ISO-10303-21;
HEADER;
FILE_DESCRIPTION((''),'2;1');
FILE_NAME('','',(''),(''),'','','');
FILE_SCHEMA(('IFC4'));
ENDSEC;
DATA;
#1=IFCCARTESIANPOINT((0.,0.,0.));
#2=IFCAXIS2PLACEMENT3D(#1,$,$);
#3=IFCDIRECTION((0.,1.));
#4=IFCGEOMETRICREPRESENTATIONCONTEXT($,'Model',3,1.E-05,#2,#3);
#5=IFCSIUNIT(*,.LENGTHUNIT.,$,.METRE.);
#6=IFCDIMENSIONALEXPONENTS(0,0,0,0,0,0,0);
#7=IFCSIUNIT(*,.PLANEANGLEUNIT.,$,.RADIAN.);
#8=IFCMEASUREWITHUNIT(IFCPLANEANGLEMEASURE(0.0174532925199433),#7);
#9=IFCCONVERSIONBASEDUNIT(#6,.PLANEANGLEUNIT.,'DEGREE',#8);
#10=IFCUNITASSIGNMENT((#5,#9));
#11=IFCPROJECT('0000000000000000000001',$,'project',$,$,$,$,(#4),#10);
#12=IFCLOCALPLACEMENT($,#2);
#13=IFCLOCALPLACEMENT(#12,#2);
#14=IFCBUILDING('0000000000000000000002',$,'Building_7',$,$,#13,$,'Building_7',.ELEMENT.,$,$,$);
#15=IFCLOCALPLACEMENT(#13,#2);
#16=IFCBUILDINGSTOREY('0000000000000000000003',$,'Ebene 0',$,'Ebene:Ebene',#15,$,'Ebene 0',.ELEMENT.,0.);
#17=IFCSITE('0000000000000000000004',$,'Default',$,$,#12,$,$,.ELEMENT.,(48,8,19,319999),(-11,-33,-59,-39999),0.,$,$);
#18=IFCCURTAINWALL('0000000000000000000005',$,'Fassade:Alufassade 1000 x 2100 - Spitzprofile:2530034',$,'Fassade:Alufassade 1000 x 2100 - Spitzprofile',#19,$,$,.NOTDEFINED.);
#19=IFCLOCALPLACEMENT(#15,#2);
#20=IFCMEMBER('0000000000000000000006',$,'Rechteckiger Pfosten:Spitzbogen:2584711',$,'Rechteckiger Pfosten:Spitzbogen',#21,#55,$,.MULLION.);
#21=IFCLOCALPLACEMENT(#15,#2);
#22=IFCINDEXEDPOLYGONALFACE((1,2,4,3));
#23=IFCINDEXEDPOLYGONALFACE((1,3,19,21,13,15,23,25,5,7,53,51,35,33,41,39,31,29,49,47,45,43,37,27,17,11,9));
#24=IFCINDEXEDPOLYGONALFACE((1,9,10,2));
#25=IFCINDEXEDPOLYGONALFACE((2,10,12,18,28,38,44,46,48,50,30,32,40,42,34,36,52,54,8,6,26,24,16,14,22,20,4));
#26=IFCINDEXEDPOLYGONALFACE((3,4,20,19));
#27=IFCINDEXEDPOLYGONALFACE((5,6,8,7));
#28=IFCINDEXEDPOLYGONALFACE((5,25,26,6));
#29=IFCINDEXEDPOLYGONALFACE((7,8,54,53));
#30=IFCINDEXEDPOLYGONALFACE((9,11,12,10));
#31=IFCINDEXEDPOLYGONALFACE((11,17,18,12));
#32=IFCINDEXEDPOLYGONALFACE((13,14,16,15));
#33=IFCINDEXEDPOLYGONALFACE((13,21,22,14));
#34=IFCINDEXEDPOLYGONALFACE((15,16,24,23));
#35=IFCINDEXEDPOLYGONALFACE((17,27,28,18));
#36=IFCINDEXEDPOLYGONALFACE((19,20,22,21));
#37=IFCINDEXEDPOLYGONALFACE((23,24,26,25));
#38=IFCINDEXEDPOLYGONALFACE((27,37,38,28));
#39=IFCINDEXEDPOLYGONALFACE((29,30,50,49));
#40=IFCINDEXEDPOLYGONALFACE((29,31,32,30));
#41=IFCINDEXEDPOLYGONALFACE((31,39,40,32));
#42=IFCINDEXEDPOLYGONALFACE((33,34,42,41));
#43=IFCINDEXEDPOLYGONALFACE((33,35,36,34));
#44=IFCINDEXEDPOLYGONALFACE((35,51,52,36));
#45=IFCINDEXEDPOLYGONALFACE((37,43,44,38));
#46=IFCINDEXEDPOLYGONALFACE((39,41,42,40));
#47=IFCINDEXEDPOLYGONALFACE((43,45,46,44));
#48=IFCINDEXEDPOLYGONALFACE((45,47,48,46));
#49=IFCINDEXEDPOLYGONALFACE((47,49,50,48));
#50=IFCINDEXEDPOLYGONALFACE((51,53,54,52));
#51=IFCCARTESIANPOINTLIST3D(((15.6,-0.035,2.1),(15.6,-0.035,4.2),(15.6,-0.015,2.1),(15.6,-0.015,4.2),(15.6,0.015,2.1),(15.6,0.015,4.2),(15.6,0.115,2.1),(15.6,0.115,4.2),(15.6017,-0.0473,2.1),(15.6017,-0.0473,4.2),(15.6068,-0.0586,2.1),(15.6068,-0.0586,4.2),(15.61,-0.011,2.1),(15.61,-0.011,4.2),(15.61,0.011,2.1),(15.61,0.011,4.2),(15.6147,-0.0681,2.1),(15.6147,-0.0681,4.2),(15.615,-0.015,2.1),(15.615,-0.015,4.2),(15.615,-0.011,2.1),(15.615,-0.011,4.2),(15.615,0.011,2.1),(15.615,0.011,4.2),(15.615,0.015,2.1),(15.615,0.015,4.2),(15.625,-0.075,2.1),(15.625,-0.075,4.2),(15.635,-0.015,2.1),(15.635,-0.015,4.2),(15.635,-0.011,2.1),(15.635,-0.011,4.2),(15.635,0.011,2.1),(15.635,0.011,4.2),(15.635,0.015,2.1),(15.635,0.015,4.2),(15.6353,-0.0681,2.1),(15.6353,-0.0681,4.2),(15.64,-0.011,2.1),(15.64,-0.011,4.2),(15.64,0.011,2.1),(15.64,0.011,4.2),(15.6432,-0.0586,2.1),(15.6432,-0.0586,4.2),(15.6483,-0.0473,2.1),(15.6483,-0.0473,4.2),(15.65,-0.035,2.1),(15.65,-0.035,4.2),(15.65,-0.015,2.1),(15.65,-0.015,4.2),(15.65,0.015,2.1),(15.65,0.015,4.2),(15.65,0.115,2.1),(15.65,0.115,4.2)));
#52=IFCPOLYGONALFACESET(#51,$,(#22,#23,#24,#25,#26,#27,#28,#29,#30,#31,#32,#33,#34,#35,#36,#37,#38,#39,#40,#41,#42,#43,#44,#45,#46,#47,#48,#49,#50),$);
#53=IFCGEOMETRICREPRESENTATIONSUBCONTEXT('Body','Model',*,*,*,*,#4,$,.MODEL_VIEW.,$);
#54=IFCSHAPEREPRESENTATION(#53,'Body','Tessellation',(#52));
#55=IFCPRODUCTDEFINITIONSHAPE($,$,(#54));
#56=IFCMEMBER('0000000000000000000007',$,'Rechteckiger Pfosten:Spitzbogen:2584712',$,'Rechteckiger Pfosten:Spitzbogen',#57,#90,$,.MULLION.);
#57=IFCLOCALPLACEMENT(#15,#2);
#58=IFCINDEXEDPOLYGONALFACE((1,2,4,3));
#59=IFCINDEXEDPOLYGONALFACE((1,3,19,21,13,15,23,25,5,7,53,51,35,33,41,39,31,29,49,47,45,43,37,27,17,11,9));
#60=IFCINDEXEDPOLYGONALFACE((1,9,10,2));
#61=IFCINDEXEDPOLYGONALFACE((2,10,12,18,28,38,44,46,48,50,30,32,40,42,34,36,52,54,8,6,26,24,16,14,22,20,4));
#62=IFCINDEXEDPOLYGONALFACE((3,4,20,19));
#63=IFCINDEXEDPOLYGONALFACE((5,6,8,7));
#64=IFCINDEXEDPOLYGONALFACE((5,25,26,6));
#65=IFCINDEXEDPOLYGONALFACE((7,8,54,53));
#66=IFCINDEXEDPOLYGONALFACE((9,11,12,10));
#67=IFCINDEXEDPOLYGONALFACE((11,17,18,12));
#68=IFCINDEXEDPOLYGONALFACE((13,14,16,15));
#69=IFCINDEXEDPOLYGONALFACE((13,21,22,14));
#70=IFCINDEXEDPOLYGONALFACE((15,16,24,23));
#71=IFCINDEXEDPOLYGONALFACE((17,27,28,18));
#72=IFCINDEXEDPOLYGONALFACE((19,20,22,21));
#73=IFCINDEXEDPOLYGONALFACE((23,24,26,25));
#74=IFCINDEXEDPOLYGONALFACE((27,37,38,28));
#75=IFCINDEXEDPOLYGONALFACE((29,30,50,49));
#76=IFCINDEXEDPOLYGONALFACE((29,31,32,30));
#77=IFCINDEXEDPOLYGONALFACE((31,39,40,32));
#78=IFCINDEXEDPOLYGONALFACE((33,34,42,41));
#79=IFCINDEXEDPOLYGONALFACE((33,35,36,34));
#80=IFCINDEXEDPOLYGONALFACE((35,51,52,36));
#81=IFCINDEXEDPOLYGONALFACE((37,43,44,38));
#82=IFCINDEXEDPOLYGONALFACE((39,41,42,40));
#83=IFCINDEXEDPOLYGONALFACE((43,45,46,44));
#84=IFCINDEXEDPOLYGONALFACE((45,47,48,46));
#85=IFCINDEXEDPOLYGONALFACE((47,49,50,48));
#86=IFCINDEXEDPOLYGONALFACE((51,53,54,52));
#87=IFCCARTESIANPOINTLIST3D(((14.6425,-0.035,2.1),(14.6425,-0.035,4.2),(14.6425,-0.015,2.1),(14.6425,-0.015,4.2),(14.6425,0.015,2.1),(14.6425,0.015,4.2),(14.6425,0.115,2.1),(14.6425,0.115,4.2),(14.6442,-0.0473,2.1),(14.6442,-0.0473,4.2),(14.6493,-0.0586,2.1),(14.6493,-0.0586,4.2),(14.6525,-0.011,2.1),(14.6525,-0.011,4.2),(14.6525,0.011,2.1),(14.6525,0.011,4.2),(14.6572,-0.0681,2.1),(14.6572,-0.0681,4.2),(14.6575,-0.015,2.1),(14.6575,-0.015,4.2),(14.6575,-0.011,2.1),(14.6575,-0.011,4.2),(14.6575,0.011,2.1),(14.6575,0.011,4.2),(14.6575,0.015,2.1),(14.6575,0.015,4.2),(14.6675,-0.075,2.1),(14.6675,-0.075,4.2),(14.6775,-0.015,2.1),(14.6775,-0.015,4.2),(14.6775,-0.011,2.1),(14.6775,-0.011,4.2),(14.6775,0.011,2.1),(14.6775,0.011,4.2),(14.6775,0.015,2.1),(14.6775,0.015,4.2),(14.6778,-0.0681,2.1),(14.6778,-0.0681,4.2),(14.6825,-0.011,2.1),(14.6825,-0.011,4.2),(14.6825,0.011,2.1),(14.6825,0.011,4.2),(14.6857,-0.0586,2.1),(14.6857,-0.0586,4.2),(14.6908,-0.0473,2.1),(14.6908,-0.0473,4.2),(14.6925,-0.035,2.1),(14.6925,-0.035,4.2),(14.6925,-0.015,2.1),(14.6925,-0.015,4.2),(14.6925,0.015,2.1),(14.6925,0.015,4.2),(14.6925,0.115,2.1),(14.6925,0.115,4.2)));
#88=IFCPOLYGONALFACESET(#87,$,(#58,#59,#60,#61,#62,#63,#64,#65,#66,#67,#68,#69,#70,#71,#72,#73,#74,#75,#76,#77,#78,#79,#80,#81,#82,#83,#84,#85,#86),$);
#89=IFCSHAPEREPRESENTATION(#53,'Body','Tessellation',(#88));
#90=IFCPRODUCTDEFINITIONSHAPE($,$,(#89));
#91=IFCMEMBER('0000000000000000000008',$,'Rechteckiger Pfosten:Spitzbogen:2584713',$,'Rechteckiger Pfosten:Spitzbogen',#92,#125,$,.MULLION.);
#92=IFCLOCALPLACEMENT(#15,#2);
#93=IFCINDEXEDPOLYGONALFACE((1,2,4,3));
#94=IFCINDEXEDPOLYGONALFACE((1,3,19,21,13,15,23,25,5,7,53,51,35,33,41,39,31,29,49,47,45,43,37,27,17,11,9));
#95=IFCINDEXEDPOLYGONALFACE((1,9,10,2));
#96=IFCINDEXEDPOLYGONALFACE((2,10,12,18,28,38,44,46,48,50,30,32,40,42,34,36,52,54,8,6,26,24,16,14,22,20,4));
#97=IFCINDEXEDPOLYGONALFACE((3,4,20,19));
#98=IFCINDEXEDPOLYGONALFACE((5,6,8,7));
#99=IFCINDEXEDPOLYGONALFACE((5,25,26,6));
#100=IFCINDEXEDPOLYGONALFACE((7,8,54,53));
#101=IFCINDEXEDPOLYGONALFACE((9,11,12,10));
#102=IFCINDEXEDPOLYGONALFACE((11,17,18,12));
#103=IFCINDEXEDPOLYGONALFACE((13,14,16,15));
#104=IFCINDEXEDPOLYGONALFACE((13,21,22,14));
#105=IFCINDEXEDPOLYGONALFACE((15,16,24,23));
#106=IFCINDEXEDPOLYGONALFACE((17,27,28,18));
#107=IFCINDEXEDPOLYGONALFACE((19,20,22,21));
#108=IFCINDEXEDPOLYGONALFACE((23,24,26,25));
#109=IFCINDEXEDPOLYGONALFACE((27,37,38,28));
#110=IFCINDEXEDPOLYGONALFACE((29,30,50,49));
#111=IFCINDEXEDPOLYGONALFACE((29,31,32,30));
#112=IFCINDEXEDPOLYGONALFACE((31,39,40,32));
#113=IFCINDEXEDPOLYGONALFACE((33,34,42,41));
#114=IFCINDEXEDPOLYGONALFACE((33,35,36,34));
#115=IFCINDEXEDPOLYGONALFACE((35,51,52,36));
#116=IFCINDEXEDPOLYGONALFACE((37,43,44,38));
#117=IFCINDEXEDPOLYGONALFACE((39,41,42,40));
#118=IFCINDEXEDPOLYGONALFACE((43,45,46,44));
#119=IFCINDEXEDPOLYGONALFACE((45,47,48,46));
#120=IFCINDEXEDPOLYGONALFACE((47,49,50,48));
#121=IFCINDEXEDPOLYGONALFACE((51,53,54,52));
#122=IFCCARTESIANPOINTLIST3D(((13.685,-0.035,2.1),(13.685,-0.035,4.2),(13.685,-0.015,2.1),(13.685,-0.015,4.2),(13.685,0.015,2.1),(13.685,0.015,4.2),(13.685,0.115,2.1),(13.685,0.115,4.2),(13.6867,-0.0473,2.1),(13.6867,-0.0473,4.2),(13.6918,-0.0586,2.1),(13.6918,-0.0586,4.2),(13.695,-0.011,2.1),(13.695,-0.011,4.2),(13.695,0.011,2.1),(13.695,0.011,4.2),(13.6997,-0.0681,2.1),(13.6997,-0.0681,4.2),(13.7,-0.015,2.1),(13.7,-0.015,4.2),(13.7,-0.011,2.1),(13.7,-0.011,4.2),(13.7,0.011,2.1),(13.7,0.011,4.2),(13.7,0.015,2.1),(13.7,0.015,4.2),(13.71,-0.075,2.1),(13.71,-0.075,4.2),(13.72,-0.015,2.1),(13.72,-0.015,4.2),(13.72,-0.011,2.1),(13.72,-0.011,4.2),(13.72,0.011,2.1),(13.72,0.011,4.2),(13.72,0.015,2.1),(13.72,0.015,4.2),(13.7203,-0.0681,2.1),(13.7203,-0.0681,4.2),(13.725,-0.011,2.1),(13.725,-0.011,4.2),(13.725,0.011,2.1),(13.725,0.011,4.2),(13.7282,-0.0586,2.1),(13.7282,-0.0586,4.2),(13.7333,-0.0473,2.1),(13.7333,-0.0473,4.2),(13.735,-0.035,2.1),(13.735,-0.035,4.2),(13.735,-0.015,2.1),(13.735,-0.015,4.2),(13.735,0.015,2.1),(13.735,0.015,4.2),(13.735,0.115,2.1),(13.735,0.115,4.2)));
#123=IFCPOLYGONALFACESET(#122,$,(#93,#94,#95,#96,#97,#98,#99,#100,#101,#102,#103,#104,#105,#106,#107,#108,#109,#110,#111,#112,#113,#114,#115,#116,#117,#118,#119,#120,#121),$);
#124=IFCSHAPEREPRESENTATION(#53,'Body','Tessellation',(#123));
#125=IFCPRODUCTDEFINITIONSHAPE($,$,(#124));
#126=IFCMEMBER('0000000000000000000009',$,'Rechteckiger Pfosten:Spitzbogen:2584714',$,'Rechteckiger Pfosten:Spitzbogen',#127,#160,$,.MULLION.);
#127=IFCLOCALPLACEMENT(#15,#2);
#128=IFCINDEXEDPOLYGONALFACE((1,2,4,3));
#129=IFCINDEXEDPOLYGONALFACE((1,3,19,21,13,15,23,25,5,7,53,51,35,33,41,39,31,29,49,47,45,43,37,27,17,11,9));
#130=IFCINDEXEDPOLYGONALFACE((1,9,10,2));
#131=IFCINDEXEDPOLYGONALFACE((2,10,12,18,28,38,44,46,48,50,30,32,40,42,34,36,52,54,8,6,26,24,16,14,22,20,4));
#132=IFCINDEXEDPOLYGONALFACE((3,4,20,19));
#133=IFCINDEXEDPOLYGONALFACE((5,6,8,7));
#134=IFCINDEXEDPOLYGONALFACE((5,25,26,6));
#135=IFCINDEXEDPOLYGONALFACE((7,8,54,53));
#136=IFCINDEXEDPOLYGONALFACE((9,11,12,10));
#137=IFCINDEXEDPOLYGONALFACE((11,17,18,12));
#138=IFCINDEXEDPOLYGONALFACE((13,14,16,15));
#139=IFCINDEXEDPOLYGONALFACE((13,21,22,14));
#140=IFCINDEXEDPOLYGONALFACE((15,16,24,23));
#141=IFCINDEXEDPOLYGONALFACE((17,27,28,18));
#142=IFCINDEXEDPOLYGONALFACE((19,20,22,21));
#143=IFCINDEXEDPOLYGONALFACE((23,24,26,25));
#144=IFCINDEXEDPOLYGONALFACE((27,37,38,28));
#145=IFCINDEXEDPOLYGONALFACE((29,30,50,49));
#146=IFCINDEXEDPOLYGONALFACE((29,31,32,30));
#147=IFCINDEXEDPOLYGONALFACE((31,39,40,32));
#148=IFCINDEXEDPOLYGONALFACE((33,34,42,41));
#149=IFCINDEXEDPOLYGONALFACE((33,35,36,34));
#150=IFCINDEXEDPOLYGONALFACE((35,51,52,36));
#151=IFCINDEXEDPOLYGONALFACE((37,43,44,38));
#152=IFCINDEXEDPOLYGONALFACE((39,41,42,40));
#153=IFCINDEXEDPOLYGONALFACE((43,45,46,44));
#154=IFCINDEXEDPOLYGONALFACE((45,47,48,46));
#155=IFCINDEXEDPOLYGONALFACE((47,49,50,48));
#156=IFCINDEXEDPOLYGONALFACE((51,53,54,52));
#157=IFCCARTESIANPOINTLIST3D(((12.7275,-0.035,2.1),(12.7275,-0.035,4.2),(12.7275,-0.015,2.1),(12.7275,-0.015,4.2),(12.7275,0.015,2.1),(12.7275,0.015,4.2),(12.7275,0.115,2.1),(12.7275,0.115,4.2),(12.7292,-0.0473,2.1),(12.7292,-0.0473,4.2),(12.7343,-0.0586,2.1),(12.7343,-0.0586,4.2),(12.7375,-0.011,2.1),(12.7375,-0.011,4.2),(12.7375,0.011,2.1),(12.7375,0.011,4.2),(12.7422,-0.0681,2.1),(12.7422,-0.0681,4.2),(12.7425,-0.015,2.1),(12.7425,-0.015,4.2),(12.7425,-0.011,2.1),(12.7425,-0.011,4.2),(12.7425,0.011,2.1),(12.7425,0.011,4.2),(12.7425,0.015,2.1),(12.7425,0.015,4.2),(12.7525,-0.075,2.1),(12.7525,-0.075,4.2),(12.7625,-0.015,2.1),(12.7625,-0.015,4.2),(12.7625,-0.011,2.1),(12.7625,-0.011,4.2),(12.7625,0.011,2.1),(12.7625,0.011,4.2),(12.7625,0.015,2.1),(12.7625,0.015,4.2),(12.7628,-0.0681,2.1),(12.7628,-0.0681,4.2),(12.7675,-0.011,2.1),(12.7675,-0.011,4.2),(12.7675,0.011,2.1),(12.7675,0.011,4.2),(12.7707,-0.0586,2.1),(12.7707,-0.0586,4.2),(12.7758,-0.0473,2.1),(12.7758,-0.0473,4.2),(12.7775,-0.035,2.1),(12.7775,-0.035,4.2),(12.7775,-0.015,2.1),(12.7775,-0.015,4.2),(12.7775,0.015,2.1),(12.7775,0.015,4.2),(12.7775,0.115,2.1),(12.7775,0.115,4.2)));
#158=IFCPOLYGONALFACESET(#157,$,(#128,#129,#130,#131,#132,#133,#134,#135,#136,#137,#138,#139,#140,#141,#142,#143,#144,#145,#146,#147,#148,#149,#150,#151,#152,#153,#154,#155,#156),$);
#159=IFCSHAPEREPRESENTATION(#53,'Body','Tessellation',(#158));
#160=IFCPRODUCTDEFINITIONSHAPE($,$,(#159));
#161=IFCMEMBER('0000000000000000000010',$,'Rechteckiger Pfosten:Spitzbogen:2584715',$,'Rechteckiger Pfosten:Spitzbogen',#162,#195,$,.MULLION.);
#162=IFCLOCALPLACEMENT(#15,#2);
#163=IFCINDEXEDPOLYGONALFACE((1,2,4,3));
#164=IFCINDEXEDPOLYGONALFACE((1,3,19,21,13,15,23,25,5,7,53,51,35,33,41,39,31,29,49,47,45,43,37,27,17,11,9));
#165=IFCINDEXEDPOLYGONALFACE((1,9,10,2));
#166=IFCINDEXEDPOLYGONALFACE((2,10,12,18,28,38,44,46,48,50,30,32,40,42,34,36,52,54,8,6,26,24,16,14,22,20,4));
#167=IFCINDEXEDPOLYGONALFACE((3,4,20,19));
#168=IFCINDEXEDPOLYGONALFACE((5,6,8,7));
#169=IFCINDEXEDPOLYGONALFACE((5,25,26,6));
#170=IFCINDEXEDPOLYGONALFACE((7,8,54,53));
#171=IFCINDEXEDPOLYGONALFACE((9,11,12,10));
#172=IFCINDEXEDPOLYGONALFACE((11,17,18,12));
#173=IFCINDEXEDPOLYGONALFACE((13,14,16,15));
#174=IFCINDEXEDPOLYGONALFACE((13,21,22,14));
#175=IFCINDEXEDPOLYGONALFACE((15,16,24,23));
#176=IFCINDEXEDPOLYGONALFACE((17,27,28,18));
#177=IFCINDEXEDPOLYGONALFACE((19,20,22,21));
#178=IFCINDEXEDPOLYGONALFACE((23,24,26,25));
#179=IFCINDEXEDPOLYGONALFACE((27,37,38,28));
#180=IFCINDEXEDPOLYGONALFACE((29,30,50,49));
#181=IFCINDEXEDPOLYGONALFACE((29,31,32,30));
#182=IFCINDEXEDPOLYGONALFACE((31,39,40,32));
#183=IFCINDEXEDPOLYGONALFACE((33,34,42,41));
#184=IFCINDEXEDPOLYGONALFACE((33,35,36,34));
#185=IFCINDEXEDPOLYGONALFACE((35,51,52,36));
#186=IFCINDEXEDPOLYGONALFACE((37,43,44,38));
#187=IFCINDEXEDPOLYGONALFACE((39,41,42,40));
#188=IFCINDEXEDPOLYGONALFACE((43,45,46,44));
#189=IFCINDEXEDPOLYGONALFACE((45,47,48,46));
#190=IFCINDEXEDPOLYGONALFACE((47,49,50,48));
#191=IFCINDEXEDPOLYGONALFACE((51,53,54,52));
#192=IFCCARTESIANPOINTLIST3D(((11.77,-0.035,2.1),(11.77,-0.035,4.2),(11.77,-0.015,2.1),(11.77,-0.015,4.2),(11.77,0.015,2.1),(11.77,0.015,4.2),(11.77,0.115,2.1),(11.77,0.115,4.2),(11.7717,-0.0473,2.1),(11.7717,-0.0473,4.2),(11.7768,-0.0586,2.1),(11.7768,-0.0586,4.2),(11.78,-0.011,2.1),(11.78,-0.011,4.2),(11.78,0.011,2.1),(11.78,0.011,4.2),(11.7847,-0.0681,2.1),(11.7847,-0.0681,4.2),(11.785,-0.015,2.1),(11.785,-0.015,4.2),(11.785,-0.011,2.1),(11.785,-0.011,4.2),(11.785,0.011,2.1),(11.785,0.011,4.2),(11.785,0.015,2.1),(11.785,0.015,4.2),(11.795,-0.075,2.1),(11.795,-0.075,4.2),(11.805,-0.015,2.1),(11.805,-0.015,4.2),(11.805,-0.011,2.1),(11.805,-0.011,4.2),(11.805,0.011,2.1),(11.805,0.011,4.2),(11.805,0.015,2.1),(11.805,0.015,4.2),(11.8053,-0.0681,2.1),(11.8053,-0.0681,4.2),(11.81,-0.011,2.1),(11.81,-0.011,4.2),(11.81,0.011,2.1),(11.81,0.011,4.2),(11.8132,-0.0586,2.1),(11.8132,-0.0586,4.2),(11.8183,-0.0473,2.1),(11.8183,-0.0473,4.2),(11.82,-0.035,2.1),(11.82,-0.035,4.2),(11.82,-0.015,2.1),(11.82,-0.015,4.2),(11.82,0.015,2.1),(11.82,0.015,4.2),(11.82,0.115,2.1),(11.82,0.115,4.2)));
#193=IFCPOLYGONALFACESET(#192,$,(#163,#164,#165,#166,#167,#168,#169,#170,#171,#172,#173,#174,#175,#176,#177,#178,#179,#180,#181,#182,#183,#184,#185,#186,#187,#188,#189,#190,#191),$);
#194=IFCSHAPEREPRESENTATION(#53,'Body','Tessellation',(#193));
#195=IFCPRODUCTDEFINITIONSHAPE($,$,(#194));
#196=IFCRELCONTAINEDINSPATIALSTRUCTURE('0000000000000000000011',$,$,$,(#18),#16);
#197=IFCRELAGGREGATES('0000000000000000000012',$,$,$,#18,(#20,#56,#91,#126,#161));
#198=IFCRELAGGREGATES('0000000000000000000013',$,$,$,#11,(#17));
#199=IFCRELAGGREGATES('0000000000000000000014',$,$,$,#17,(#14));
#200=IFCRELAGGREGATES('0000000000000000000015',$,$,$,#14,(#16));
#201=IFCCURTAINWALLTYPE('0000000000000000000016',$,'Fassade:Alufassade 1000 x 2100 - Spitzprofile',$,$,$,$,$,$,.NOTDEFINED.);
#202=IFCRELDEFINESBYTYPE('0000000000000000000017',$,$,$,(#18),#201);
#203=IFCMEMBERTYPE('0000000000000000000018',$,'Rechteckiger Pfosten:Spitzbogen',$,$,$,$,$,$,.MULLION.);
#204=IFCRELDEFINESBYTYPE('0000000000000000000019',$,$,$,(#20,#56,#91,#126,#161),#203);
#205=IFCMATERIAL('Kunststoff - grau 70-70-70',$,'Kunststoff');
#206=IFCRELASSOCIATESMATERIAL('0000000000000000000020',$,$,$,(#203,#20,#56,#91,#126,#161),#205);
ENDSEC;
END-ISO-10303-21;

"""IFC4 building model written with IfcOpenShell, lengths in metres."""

from ifc_helpers import new_model, entity, si_unit, converted_unit, direction, frame, origin, place, context, subcontext, project, spatial, line, arc, indexed_curve, outline, extrude, source, transform, mapped, material, type_object, type_shapes, element, aggregate, save


model = new_model("IFC4")

# Units and contexts
model_context = context("Model", 3, precision=1e-05, world=origin(), true_north=direction((0.0, 1.0)))
body_context = subcontext(model_context, "Body", "Model", "MODEL_VIEW")
ifc_project = project(units=[si_unit("LENGTHUNIT", "METRE"), converted_unit("PLANEANGLEUNIT", "DEGREE", entity("IfcPlaneAngleMeasure", 0.0174532925199433), si_unit("PLANEANGLEUNIT", "RADIAN"), dimensions=[0, 0, 0, 0, 0, 0, 0])], contexts=[model_context])

# Site, building, storey
site_placement = place(None, origin())
site = spatial("IfcSite", under=ifc_project, at=site_placement, Name="Default", CompositionType="ELEMENT", RefLatitude=(48, 8, 19, 319999), RefLongitude=(-11, -33, -59, -39999), RefElevation=0.0)
building_placement = place(site_placement, origin())
building = spatial("IfcBuilding", under=site, at=building_placement, Name="Building_7", LongName="Building_7", CompositionType="ELEMENT")
storey_placement = place(building_placement, origin())
storey = spatial("IfcBuildingStorey", under=building, at=storey_placement, Name="Ebene 0", ObjectType="Ebene:Ebene", LongName="Ebene 0", CompositionType="ELEMENT", Elevation=0.0)

# Curtain wall, members
curtain_wall_type = type_object("IfcCurtainWallType", Name="Fassade:Alufassade 1000 x 2100 - Spitzprofile", PredefinedType="NOTDEFINED")
curtain_wall_placement = place(storey_placement, origin())
curtain_wall = element("IfcCurtainWall", 1, at=curtain_wall_placement, inside=storey, type_object=curtain_wall_type, Name="Fassade:Alufassade 1000 x 2100 - Spitzprofile:2530034", ObjectType="Fassade:Alufassade 1000 x 2100 - Spitzprofile", PredefinedType="NOTDEFINED")
ifc_material = material(Name="Kunststoff - grau 70-70-70", Category="Kunststoff")
member_type_1 = type_object("IfcMemberType", Name="Rechteckiger Pfosten:Spitzbogen", PredefinedType="MULLION", material=ifc_material)
shared_shape_1 = source(origin(), body_context, "Body", "SweptSolid", [
    extrude(outline(indexed_curve([(-0.111, -0.025), (-0.011, -0.025), (-0.011, -0.01), (-0.007, -0.01), (-0.007, -0.015), (0.015, -0.015), (0.015, -0.01), (0.019, -0.01), (0.019, -0.025), (0.039, -0.025), (0.0626, -0.0182), (0.079, 0.0), (0.0626, 0.0182), (0.039, 0.025), (0.019, 0.025), (0.019, 0.01), (0.015, 0.01), (0.015, 0.015), (-0.007, 0.015), (-0.007, 0.01), (-0.011, 0.01), (-0.011, 0.025), (-0.111, 0.025)], segments=[line(1, 2, 3, 4, 5, 6, 7, 8, 9, 10), arc(10, 11, 12), arc(12, 13, 14), line(14, 15, 16, 17, 18, 19, 20, 21, 22, 23, 1)], self_intersect=False)), frame((0.0, 0.004, -2.1), z_axis=(0.0, 0.0, 1.0), x_axis=(0.0, -1.0, 0.0)), (0.0, 0.0, 1.0), 2.1),
])
type_shapes(member_type_1, [shared_shape_1])
member_1_placement = place(curtain_wall_placement, frame((15.625, 0.0, 2.1), z_axis=(0.0, 0.0, -1.0), x_axis=(-1.0, 0.0, 0.0)))
member_1 = element("IfcMember", 2, at=member_1_placement, type_object=member_type_1, material=ifc_material, Name="Rechteckiger Pfosten:Spitzbogen:2584711", ObjectType="Rechteckiger Pfosten:Spitzbogen", PredefinedType="MULLION", context=body_context, shape_type="MappedRepresentation", body=[
    mapped(shared_shape_1, transform((0.0, 0.0, 0.0), scale=1.0)),
])
member_2_placement = place(curtain_wall_placement, frame((14.6675, 0.0, 2.1), z_axis=(0.0, 0.0, -1.0), x_axis=(-1.0, 0.0, 0.0)))
member_2 = element("IfcMember", 3, at=member_2_placement, type_object=member_type_1, material=ifc_material, Name="Rechteckiger Pfosten:Spitzbogen:2584712", ObjectType="Rechteckiger Pfosten:Spitzbogen", PredefinedType="MULLION", context=body_context, shape_type="MappedRepresentation", body=[
    mapped(shared_shape_1, transform((0.0, 0.0, 0.0), scale=1.0)),
])
member_3_placement = place(curtain_wall_placement, frame((13.71, 0.0, 2.1), z_axis=(0.0, 0.0, -1.0), x_axis=(-1.0, 0.0, 0.0)))
member_3 = element("IfcMember", 4, at=member_3_placement, type_object=member_type_1, material=ifc_material, Name="Rechteckiger Pfosten:Spitzbogen:2584713", ObjectType="Rechteckiger Pfosten:Spitzbogen", PredefinedType="MULLION", context=body_context, shape_type="MappedRepresentation", body=[
    mapped(shared_shape_1, transform((0.0, 0.0, 0.0), scale=1.0)),
])
member_4_placement = place(curtain_wall_placement, frame((12.7525, 0.0, 2.1), z_axis=(0.0, 0.0, -1.0), x_axis=(-1.0, 0.0, 0.0)))
member_4 = element("IfcMember", 5, at=member_4_placement, type_object=member_type_1, material=ifc_material, Name="Rechteckiger Pfosten:Spitzbogen:2584714", ObjectType="Rechteckiger Pfosten:Spitzbogen", PredefinedType="MULLION", context=body_context, shape_type="MappedRepresentation", body=[
    mapped(shared_shape_1, transform((0.0, 0.0, 0.0), scale=1.0)),
])
member_5_placement = place(curtain_wall_placement, frame((11.795, 0.0, 2.1), z_axis=(0.0, 0.0, -1.0), x_axis=(-1.0, 0.0, 0.0)))
member_5 = element("IfcMember", 6, at=member_5_placement, type_object=member_type_1, material=ifc_material, Name="Rechteckiger Pfosten:Spitzbogen:2584715", ObjectType="Rechteckiger Pfosten:Spitzbogen", PredefinedType="MULLION", context=body_context, shape_type="MappedRepresentation", body=[
    mapped(shared_shape_1, transform((0.0, 0.0, 0.0), scale=1.0)),
])
aggregate(curtain_wall, [member_1, member_2, member_3, member_4, member_5])

save(model, "model.ifc")
